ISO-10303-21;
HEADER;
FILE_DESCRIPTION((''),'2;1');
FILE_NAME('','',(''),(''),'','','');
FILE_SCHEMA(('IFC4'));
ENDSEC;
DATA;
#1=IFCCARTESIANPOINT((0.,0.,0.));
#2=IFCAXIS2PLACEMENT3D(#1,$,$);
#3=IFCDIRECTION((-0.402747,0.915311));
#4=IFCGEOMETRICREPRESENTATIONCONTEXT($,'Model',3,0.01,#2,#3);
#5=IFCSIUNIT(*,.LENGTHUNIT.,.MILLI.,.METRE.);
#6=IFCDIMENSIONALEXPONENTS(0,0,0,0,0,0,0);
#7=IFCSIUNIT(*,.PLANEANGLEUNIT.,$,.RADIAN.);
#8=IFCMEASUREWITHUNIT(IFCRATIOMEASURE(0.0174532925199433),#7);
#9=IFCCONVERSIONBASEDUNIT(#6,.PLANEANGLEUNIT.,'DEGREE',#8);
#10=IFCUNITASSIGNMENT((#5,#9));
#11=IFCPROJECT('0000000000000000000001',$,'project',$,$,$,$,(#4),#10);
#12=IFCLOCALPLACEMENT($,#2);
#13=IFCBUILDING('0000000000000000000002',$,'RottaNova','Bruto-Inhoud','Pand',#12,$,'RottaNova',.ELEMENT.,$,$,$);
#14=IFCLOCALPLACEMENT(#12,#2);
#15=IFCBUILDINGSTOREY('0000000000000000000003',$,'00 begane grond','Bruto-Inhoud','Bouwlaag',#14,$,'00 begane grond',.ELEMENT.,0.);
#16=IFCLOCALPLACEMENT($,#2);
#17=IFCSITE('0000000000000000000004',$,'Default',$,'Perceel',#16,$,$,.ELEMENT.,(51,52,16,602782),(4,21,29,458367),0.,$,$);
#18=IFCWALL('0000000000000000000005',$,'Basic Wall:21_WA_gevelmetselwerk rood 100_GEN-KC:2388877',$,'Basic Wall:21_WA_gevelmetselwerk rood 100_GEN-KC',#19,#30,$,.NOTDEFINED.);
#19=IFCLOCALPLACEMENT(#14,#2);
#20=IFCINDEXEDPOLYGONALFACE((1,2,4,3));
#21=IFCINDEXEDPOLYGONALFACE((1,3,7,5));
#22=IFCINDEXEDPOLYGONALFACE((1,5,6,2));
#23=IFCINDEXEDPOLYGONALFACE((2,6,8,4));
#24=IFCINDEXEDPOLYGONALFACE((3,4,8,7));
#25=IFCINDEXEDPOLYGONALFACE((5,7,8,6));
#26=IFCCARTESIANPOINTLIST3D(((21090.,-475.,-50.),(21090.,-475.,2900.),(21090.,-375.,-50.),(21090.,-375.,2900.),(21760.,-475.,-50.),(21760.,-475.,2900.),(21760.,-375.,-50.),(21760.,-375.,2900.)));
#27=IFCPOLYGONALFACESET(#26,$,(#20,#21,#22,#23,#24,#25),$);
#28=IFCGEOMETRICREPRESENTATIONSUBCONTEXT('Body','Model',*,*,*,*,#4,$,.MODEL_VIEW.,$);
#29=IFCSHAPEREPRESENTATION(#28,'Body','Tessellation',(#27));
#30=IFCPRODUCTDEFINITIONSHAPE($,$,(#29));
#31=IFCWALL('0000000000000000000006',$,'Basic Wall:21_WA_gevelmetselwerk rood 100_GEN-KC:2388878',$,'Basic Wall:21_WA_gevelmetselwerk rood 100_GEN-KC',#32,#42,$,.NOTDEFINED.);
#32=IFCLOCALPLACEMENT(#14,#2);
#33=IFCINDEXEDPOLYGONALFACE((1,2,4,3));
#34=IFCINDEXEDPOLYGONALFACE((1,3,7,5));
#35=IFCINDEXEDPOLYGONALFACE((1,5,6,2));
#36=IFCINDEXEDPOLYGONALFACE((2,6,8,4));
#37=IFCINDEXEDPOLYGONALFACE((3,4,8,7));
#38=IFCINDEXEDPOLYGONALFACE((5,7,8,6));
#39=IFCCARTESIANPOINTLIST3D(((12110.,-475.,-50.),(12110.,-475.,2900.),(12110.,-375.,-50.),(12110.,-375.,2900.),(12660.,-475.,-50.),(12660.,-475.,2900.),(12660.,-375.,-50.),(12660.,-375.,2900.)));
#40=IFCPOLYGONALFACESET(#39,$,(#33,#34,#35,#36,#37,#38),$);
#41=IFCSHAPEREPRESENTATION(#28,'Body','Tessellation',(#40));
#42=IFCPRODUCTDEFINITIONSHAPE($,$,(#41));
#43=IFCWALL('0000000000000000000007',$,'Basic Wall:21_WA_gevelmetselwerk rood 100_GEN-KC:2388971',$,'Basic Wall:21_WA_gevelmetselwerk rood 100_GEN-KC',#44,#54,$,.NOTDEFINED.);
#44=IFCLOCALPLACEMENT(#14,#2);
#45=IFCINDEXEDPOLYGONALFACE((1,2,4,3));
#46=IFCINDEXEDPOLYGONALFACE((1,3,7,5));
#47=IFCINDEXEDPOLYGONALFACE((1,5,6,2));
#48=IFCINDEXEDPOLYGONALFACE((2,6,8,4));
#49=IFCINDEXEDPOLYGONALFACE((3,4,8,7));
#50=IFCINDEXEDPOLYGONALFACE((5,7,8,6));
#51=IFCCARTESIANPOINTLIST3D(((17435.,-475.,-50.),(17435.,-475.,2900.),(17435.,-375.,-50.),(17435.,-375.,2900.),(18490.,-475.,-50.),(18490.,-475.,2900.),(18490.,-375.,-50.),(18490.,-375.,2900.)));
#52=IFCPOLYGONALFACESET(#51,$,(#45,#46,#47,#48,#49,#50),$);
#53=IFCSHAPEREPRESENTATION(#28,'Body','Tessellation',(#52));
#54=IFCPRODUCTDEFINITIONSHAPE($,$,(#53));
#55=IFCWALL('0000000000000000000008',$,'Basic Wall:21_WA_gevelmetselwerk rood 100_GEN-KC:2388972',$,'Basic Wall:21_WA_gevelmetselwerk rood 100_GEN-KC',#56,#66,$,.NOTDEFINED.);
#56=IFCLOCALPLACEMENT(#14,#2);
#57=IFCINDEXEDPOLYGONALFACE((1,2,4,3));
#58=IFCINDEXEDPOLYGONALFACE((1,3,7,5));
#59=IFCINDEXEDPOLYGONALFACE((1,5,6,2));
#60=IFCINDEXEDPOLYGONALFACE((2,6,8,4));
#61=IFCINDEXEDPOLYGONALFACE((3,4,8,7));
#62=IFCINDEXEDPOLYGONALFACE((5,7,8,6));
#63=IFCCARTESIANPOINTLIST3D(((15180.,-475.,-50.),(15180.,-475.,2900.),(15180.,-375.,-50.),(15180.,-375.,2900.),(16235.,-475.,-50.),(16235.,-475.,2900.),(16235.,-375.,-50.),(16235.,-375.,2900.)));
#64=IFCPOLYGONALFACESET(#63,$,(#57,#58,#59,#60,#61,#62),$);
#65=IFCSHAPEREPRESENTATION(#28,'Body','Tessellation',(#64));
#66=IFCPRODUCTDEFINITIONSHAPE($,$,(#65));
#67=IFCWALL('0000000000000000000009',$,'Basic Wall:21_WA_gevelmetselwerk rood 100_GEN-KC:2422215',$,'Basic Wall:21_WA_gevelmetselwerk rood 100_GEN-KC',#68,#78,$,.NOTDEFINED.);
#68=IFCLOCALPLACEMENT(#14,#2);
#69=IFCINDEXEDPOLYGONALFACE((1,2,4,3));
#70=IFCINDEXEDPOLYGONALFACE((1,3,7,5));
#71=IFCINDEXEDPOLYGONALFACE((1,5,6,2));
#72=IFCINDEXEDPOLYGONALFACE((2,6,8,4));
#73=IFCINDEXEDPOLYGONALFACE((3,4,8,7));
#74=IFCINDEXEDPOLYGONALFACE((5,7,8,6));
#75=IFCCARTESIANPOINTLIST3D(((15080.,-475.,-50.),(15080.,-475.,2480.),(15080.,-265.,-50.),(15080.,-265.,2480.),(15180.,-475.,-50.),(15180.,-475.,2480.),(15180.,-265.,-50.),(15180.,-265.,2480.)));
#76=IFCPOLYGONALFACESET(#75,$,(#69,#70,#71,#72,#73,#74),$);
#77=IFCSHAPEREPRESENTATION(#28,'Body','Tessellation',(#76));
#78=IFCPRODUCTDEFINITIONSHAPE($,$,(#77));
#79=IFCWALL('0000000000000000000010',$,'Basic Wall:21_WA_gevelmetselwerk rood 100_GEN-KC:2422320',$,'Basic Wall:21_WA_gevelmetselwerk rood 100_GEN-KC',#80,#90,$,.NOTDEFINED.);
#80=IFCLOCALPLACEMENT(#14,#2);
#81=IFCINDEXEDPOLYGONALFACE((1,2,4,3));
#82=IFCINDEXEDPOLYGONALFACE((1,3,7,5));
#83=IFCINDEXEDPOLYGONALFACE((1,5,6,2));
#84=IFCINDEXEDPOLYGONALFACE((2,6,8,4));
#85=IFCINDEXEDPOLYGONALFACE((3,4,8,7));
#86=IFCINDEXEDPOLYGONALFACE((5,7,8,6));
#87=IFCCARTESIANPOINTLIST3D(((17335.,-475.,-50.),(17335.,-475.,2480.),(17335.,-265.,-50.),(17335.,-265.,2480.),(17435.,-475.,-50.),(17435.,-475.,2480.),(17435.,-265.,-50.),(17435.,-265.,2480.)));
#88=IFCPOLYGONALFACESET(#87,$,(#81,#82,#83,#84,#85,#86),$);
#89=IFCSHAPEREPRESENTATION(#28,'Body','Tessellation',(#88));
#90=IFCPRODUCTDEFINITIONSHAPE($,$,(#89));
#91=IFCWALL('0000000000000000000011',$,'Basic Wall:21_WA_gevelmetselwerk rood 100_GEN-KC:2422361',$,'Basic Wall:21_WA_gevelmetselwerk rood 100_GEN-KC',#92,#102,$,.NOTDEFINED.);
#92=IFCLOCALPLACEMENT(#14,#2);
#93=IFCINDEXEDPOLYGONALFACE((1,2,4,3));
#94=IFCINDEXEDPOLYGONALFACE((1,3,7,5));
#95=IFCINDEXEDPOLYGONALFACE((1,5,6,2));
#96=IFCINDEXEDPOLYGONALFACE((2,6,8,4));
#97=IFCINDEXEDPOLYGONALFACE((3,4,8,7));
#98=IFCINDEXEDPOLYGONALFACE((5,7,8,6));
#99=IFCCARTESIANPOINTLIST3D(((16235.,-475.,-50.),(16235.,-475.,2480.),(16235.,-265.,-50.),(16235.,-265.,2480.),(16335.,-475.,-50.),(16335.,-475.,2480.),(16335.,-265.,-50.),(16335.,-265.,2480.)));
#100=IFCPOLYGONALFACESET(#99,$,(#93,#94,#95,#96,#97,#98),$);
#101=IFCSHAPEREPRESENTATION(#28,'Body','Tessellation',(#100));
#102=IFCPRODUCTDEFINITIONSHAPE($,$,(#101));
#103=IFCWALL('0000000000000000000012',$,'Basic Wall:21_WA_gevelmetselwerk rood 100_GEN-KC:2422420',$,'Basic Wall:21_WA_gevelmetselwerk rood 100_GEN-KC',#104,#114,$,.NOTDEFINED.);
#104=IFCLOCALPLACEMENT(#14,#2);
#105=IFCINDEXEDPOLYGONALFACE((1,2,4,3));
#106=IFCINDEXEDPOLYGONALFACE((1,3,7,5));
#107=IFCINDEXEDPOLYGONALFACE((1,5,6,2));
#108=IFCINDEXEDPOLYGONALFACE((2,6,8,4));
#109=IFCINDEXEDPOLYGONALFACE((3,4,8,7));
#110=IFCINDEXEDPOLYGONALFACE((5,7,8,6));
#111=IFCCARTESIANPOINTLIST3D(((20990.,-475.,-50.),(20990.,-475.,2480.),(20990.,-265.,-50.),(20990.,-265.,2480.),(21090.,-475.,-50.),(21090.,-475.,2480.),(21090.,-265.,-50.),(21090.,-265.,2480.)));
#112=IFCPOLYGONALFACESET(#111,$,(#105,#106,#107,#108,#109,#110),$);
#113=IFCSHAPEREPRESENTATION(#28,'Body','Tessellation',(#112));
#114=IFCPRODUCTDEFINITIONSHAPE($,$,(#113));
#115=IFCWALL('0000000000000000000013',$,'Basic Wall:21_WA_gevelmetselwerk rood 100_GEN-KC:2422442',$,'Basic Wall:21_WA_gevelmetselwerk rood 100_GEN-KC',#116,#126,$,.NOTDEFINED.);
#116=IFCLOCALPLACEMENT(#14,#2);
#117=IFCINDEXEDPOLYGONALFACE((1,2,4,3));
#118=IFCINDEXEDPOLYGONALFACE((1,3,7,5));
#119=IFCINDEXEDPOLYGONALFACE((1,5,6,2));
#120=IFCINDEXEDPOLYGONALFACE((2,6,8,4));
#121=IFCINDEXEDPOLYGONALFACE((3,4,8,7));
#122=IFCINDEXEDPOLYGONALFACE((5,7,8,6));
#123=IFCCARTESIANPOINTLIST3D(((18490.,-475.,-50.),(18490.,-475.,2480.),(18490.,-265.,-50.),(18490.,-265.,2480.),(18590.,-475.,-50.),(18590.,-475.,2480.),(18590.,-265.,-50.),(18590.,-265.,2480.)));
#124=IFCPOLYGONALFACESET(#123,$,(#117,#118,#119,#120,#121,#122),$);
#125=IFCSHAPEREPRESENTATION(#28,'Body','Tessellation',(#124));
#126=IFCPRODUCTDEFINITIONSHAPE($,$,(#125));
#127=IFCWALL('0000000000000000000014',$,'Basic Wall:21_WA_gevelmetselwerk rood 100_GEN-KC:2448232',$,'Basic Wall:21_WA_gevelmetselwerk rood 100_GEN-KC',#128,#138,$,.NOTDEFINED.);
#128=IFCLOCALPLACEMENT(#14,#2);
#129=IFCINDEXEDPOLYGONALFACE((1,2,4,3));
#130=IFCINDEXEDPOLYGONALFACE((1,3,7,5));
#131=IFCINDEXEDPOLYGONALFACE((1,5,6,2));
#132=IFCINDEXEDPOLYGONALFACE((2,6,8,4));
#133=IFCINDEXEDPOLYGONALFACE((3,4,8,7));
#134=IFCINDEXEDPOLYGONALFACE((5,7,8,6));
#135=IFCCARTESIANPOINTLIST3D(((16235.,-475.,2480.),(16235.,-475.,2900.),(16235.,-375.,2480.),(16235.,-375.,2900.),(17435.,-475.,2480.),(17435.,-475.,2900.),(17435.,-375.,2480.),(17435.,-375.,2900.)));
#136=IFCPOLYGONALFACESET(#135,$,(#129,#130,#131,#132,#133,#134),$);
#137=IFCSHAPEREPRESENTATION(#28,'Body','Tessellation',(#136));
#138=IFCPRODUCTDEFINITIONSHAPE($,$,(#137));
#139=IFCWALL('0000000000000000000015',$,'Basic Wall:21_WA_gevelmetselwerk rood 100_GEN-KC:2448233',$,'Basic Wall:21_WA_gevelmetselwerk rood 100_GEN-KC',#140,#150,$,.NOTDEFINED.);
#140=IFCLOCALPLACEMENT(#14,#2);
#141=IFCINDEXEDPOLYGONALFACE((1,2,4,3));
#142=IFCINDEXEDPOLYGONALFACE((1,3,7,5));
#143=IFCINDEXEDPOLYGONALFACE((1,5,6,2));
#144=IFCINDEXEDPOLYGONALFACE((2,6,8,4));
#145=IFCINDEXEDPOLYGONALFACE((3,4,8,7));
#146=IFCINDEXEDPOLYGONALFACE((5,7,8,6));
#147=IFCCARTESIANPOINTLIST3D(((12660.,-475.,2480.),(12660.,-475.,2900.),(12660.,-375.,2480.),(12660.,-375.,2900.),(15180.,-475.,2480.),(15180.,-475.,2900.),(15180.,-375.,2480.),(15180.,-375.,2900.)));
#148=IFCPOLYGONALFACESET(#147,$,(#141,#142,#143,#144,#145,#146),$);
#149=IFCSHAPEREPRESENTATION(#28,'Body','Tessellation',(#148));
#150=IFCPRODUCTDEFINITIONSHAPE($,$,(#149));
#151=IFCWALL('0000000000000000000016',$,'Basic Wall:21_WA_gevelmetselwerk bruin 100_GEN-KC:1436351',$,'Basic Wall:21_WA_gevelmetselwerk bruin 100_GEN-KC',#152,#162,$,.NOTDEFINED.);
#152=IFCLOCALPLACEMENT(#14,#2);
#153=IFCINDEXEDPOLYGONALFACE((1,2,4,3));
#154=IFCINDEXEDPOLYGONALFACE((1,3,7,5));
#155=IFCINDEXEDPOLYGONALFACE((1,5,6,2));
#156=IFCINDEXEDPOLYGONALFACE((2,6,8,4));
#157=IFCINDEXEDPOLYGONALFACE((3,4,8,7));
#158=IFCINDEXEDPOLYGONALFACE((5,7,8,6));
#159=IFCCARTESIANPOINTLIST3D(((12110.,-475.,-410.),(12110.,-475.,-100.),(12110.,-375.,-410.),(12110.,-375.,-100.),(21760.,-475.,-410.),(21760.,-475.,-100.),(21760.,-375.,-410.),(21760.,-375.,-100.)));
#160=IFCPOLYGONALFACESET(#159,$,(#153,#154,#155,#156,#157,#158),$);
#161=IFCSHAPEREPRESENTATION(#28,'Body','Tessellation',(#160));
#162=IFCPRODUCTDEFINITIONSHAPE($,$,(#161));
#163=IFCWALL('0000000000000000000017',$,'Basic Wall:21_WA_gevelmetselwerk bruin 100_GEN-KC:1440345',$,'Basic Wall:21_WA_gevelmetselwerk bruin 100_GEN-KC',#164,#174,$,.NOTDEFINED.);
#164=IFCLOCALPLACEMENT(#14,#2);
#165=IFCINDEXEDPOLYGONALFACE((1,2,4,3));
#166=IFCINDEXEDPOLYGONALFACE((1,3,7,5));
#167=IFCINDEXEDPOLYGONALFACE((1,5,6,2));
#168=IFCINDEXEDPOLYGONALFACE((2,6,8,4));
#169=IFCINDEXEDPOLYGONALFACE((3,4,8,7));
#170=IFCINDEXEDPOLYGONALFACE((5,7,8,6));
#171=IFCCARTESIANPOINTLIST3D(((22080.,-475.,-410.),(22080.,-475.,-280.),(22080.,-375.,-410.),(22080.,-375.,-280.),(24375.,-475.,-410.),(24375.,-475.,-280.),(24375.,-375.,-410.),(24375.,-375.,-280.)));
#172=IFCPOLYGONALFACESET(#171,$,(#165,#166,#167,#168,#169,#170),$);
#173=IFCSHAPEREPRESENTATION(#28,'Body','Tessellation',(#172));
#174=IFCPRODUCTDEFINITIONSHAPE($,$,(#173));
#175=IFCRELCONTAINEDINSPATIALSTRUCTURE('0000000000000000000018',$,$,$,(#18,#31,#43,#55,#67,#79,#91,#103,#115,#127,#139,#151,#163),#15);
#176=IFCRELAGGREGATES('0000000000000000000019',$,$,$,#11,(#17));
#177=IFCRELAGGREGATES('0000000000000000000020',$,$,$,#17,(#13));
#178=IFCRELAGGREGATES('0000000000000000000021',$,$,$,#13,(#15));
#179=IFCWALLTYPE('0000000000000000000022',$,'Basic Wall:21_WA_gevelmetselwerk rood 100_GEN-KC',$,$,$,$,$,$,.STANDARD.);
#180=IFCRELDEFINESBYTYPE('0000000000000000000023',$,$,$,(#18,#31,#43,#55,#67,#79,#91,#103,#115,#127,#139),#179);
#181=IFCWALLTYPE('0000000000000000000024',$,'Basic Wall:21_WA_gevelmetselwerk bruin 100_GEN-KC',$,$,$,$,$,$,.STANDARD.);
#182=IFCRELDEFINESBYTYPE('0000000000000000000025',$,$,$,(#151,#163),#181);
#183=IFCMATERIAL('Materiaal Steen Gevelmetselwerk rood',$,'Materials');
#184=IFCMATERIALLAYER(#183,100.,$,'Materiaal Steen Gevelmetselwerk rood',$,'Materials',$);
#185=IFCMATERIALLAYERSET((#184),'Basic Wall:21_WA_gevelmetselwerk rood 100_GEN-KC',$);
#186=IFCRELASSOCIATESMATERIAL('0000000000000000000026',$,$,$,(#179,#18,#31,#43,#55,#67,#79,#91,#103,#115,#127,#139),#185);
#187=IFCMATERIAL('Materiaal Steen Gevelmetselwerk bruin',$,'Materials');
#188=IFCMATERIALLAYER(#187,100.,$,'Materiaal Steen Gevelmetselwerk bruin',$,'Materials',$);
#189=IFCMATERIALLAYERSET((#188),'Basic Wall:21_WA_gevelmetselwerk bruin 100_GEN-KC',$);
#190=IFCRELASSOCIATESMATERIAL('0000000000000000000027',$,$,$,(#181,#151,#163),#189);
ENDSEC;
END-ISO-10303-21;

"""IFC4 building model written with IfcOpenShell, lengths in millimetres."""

from ifc_helpers import new_model, entity, si_unit, converted_unit, direction, frame, frame_2d, origin, place, context, subcontext, project, spatial, rectangle, extrude, material, layer, layer_set, type_object, element, save


model = new_model("IFC4")

# Units and contexts
model_context = context("Model", 3, precision=0.01, world=origin(), true_north=direction((-0.402747, 0.915311)))
body_context = subcontext(model_context, "Body", "Model", "MODEL_VIEW")
ifc_project = project(units=[si_unit("LENGTHUNIT", "METRE", prefix="MILLI"), converted_unit("PLANEANGLEUNIT", "DEGREE", entity("IfcRatioMeasure", 0.0174532925199433), si_unit("PLANEANGLEUNIT", "RADIAN"), dimensions=[0, 0, 0, 0, 0, 0, 0])], contexts=[model_context])

# Site, building, storey
site_placement = place(None, origin())
site = spatial("IfcSite", under=ifc_project, at=site_placement, Name="Default", ObjectType="Perceel", CompositionType="ELEMENT", RefLatitude=(51, 52, 16, 602782), RefLongitude=(4, 21, 29, 458367), RefElevation=0.0)
building_placement = place(None, origin())
building = spatial("IfcBuilding", under=site, at=building_placement, Name="RottaNova", Description="Bruto-Inhoud", ObjectType="Pand", LongName="RottaNova", CompositionType="ELEMENT")
storey_placement = place(building_placement, origin())
storey = spatial("IfcBuildingStorey", under=building, at=storey_placement, Name="00 begane grond", Description="Bruto-Inhoud", ObjectType="Bouwlaag", LongName="00 begane grond", CompositionType="ELEMENT", Elevation=0.0)

# Walls
ifc_material_1 = material(Name="Materiaal Steen Gevelmetselwerk rood", Category="Materials")
ifc_layer_1 = layer(ifc_material_1, 100.0, Name="Materiaal Steen Gevelmetselwerk rood", Category="Materials")
ifc_layer_set_1 = layer_set([ifc_layer_1], Name="Basic Wall:21_WA_gevelmetselwerk rood 100_GEN-KC")
wall_type_1 = type_object("IfcWallType", Name="Basic Wall:21_WA_gevelmetselwerk rood 100_GEN-KC", PredefinedType="STANDARD", material=ifc_layer_set_1)
wall_1_placement = place(storey_placement, frame((21760.0, -425.0, -50.0), z_axis=(0.0, 0.0, 1.0), x_axis=(-1.0, 0.0, 0.0)))
element("IfcWall", 1, at=wall_1_placement, inside=storey, type_object=wall_type_1, material=ifc_layer_set_1, Name="Basic Wall:21_WA_gevelmetselwerk rood 100_GEN-KC:2388877", ObjectType="Basic Wall:21_WA_gevelmetselwerk rood 100_GEN-KC", PredefinedType="NOTDEFINED", context=body_context, shape_type="SweptSolid", body=[
    extrude(rectangle(XDim=670.0, YDim=100.0, at=frame_2d((335.0, 0.0), x_axis=(-1.0, 0.0))), origin(), (0.0, 0.0, 1.0), 2950.0),
])
wall_2_placement = place(storey_placement, frame((12660.0, -425.0, -50.0), z_axis=(0.0, 0.0, 1.0), x_axis=(-1.0, 0.0, 0.0)))
element("IfcWall", 2, at=wall_2_placement, inside=storey, type_object=wall_type_1, material=ifc_layer_set_1, Name="Basic Wall:21_WA_gevelmetselwerk rood 100_GEN-KC:2388878", ObjectType="Basic Wall:21_WA_gevelmetselwerk rood 100_GEN-KC", PredefinedType="NOTDEFINED", context=body_context, shape_type="SweptSolid", body=[
    extrude(rectangle(XDim=550.0, YDim=100.0, at=frame_2d((275.0, 0.0), x_axis=(-1.0, 0.0))), origin(), (0.0, 0.0, 1.0), 2950.0),
])
wall_3_placement = place(storey_placement, frame((18490.0, -425.0, -50.0), z_axis=(0.0, 0.0, 1.0), x_axis=(-1.0, 0.0, 0.0)))
element("IfcWall", 3, at=wall_3_placement, inside=storey, type_object=wall_type_1, material=ifc_layer_set_1, Name="Basic Wall:21_WA_gevelmetselwerk rood 100_GEN-KC:2388971", ObjectType="Basic Wall:21_WA_gevelmetselwerk rood 100_GEN-KC", PredefinedType="NOTDEFINED", context=body_context, shape_type="SweptSolid", body=[
    extrude(rectangle(XDim=1055.0, YDim=100.0, at=frame_2d((527.5, 0.0), x_axis=(-1.0, 0.0))), origin(), (0.0, 0.0, 1.0), 2950.0),
])
wall_4_placement = place(storey_placement, frame((16235.0, -425.0, -50.0), z_axis=(0.0, 0.0, 1.0), x_axis=(-1.0, 0.0, 0.0)))
element("IfcWall", 4, at=wall_4_placement, inside=storey, type_object=wall_type_1, material=ifc_layer_set_1, Name="Basic Wall:21_WA_gevelmetselwerk rood 100_GEN-KC:2388972", ObjectType="Basic Wall:21_WA_gevelmetselwerk rood 100_GEN-KC", PredefinedType="NOTDEFINED", context=body_context, shape_type="SweptSolid", body=[
    extrude(rectangle(XDim=1055.0, YDim=100.0, at=frame_2d((527.5, 0.0), x_axis=(-1.0, 0.0))), origin(), (0.0, 0.0, 1.0), 2950.0),
])
wall_5_placement = place(storey_placement, frame((15130.0, -265.0, -50.0), z_axis=(0.0, 0.0, 1.0), x_axis=(0.0, -1.0, 0.0)))
element("IfcWall", 5, at=wall_5_placement, inside=storey, type_object=wall_type_1, material=ifc_layer_set_1, Name="Basic Wall:21_WA_gevelmetselwerk rood 100_GEN-KC:2422215", ObjectType="Basic Wall:21_WA_gevelmetselwerk rood 100_GEN-KC", PredefinedType="NOTDEFINED", context=body_context, shape_type="SweptSolid", body=[
    extrude(rectangle(XDim=210.0, YDim=100.0, at=frame_2d((105.0, 0.0), x_axis=(-1.0, 0.0))), origin(), (0.0, 0.0, 1.0), 2530.0),
])
wall_6_placement = place(storey_placement, frame((17385.0, -265.0, -50.0), z_axis=(0.0, 0.0, 1.0), x_axis=(0.0, -1.0, 0.0)))
element("IfcWall", 6, at=wall_6_placement, inside=storey, type_object=wall_type_1, material=ifc_layer_set_1, Name="Basic Wall:21_WA_gevelmetselwerk rood 100_GEN-KC:2422320", ObjectType="Basic Wall:21_WA_gevelmetselwerk rood 100_GEN-KC", PredefinedType="NOTDEFINED", context=body_context, shape_type="SweptSolid", body=[
    extrude(rectangle(XDim=210.0, YDim=100.0, at=frame_2d((105.0, 0.0), x_axis=(-1.0, 0.0))), origin(), (0.0, 0.0, 1.0), 2530.0),
])
wall_7_placement = place(storey_placement, frame((16285.0, -265.0, -50.0), z_axis=(0.0, 0.0, 1.0), x_axis=(0.0, -1.0, 0.0)))
element("IfcWall", 7, at=wall_7_placement, inside=storey, type_object=wall_type_1, material=ifc_layer_set_1, Name="Basic Wall:21_WA_gevelmetselwerk rood 100_GEN-KC:2422361", ObjectType="Basic Wall:21_WA_gevelmetselwerk rood 100_GEN-KC", PredefinedType="NOTDEFINED", context=body_context, shape_type="SweptSolid", body=[
    extrude(rectangle(XDim=210.0, YDim=100.0, at=frame_2d((105.0, 0.0), x_axis=(-1.0, 0.0))), origin(), (0.0, 0.0, 1.0), 2530.0),
])
wall_8_placement = place(storey_placement, frame((21040.0, -265.0, -50.0), z_axis=(0.0, 0.0, 1.0), x_axis=(0.0, -1.0, 0.0)))
element("IfcWall", 8, at=wall_8_placement, inside=storey, type_object=wall_type_1, material=ifc_layer_set_1, Name="Basic Wall:21_WA_gevelmetselwerk rood 100_GEN-KC:2422420", ObjectType="Basic Wall:21_WA_gevelmetselwerk rood 100_GEN-KC", PredefinedType="NOTDEFINED", context=body_context, shape_type="SweptSolid", body=[
    extrude(rectangle(XDim=210.0, YDim=100.0, at=frame_2d((105.0, 0.0), x_axis=(-1.0, 0.0))), origin(), (0.0, 0.0, 1.0), 2530.0),
])
wall_9_placement = place(storey_placement, frame((18540.0, -265.0, -50.0), z_axis=(0.0, 0.0, 1.0), x_axis=(0.0, -1.0, 0.0)))
element("IfcWall", 9, at=wall_9_placement, inside=storey, type_object=wall_type_1, material=ifc_layer_set_1, Name="Basic Wall:21_WA_gevelmetselwerk rood 100_GEN-KC:2422442", ObjectType="Basic Wall:21_WA_gevelmetselwerk rood 100_GEN-KC", PredefinedType="NOTDEFINED", context=body_context, shape_type="SweptSolid", body=[
    extrude(rectangle(XDim=210.0, YDim=100.0, at=frame_2d((105.0, 0.0), x_axis=(-1.0, 0.0))), origin(), (0.0, 0.0, 1.0), 2530.0),
])
wall_10_placement = place(storey_placement, frame((17435.0, -425.0, 2480.0), z_axis=(0.0, 0.0, 1.0), x_axis=(-1.0, 0.0, 0.0)))
element("IfcWall", 10, at=wall_10_placement, inside=storey, type_object=wall_type_1, material=ifc_layer_set_1, Name="Basic Wall:21_WA_gevelmetselwerk rood 100_GEN-KC:2448232", ObjectType="Basic Wall:21_WA_gevelmetselwerk rood 100_GEN-KC", PredefinedType="NOTDEFINED", context=body_context, shape_type="SweptSolid", body=[
    extrude(rectangle(XDim=1200.0, YDim=100.0, at=frame_2d((600.0, 0.0), x_axis=(-1.0, 0.0))), origin(), (0.0, 0.0, 1.0), 420.0),
])
wall_11_placement = place(storey_placement, frame((15180.0, -425.0, 2480.0), z_axis=(0.0, 0.0, 1.0), x_axis=(-1.0, 0.0, 0.0)))
element("IfcWall", 11, at=wall_11_placement, inside=storey, type_object=wall_type_1, material=ifc_layer_set_1, Name="Basic Wall:21_WA_gevelmetselwerk rood 100_GEN-KC:2448233", ObjectType="Basic Wall:21_WA_gevelmetselwerk rood 100_GEN-KC", PredefinedType="NOTDEFINED", context=body_context, shape_type="SweptSolid", body=[
    extrude(rectangle(XDim=2520.0, YDim=100.0, at=frame_2d((1260.0, 0.0), x_axis=(-1.0, 0.0))), origin(), (0.0, 0.0, 1.0), 420.0),
])
ifc_material_2 = material(Name="Materiaal Steen Gevelmetselwerk bruin", Category="Materials")
ifc_layer_2 = layer(ifc_material_2, 100.0, Name="Materiaal Steen Gevelmetselwerk bruin", Category="Materials")
ifc_layer_set_2 = layer_set([ifc_layer_2], Name="Basic Wall:21_WA_gevelmetselwerk bruin 100_GEN-KC")
wall_type_2 = type_object("IfcWallType", Name="Basic Wall:21_WA_gevelmetselwerk bruin 100_GEN-KC", PredefinedType="STANDARD", material=ifc_layer_set_2)
wall_12_placement = place(storey_placement, frame((21760.0, -425.0, -410.0), z_axis=(0.0, 0.0, 1.0), x_axis=(-1.0, 0.0, 0.0)))
element("IfcWall", 12, at=wall_12_placement, inside=storey, type_object=wall_type_2, material=ifc_layer_set_2, Name="Basic Wall:21_WA_gevelmetselwerk bruin 100_GEN-KC:1436351", ObjectType="Basic Wall:21_WA_gevelmetselwerk bruin 100_GEN-KC", PredefinedType="NOTDEFINED", context=body_context, shape_type="SweptSolid", body=[
    extrude(rectangle(XDim=9650.0, YDim=100.0, at=frame_2d((4825.0, 0.0), x_axis=(-1.0, 0.0))), origin(), (0.0, 0.0, 1.0), 310.0),
])
wall_13_placement = place(storey_placement, frame((22080.0, -425.0, -410.0)))
element("IfcWall", 13, at=wall_13_placement, inside=storey, type_object=wall_type_2, material=ifc_layer_set_2, Name="Basic Wall:21_WA_gevelmetselwerk bruin 100_GEN-KC:1440345", ObjectType="Basic Wall:21_WA_gevelmetselwerk bruin 100_GEN-KC", PredefinedType="NOTDEFINED", context=body_context, shape_type="SweptSolid", body=[
    extrude(rectangle(XDim=2295.0, YDim=100.0, at=frame_2d((1147.5, 0.0), x_axis=(-1.0, 0.0))), origin(), (0.0, 0.0, 1.0), 130.0),
])

save(model, "model.ifc")
